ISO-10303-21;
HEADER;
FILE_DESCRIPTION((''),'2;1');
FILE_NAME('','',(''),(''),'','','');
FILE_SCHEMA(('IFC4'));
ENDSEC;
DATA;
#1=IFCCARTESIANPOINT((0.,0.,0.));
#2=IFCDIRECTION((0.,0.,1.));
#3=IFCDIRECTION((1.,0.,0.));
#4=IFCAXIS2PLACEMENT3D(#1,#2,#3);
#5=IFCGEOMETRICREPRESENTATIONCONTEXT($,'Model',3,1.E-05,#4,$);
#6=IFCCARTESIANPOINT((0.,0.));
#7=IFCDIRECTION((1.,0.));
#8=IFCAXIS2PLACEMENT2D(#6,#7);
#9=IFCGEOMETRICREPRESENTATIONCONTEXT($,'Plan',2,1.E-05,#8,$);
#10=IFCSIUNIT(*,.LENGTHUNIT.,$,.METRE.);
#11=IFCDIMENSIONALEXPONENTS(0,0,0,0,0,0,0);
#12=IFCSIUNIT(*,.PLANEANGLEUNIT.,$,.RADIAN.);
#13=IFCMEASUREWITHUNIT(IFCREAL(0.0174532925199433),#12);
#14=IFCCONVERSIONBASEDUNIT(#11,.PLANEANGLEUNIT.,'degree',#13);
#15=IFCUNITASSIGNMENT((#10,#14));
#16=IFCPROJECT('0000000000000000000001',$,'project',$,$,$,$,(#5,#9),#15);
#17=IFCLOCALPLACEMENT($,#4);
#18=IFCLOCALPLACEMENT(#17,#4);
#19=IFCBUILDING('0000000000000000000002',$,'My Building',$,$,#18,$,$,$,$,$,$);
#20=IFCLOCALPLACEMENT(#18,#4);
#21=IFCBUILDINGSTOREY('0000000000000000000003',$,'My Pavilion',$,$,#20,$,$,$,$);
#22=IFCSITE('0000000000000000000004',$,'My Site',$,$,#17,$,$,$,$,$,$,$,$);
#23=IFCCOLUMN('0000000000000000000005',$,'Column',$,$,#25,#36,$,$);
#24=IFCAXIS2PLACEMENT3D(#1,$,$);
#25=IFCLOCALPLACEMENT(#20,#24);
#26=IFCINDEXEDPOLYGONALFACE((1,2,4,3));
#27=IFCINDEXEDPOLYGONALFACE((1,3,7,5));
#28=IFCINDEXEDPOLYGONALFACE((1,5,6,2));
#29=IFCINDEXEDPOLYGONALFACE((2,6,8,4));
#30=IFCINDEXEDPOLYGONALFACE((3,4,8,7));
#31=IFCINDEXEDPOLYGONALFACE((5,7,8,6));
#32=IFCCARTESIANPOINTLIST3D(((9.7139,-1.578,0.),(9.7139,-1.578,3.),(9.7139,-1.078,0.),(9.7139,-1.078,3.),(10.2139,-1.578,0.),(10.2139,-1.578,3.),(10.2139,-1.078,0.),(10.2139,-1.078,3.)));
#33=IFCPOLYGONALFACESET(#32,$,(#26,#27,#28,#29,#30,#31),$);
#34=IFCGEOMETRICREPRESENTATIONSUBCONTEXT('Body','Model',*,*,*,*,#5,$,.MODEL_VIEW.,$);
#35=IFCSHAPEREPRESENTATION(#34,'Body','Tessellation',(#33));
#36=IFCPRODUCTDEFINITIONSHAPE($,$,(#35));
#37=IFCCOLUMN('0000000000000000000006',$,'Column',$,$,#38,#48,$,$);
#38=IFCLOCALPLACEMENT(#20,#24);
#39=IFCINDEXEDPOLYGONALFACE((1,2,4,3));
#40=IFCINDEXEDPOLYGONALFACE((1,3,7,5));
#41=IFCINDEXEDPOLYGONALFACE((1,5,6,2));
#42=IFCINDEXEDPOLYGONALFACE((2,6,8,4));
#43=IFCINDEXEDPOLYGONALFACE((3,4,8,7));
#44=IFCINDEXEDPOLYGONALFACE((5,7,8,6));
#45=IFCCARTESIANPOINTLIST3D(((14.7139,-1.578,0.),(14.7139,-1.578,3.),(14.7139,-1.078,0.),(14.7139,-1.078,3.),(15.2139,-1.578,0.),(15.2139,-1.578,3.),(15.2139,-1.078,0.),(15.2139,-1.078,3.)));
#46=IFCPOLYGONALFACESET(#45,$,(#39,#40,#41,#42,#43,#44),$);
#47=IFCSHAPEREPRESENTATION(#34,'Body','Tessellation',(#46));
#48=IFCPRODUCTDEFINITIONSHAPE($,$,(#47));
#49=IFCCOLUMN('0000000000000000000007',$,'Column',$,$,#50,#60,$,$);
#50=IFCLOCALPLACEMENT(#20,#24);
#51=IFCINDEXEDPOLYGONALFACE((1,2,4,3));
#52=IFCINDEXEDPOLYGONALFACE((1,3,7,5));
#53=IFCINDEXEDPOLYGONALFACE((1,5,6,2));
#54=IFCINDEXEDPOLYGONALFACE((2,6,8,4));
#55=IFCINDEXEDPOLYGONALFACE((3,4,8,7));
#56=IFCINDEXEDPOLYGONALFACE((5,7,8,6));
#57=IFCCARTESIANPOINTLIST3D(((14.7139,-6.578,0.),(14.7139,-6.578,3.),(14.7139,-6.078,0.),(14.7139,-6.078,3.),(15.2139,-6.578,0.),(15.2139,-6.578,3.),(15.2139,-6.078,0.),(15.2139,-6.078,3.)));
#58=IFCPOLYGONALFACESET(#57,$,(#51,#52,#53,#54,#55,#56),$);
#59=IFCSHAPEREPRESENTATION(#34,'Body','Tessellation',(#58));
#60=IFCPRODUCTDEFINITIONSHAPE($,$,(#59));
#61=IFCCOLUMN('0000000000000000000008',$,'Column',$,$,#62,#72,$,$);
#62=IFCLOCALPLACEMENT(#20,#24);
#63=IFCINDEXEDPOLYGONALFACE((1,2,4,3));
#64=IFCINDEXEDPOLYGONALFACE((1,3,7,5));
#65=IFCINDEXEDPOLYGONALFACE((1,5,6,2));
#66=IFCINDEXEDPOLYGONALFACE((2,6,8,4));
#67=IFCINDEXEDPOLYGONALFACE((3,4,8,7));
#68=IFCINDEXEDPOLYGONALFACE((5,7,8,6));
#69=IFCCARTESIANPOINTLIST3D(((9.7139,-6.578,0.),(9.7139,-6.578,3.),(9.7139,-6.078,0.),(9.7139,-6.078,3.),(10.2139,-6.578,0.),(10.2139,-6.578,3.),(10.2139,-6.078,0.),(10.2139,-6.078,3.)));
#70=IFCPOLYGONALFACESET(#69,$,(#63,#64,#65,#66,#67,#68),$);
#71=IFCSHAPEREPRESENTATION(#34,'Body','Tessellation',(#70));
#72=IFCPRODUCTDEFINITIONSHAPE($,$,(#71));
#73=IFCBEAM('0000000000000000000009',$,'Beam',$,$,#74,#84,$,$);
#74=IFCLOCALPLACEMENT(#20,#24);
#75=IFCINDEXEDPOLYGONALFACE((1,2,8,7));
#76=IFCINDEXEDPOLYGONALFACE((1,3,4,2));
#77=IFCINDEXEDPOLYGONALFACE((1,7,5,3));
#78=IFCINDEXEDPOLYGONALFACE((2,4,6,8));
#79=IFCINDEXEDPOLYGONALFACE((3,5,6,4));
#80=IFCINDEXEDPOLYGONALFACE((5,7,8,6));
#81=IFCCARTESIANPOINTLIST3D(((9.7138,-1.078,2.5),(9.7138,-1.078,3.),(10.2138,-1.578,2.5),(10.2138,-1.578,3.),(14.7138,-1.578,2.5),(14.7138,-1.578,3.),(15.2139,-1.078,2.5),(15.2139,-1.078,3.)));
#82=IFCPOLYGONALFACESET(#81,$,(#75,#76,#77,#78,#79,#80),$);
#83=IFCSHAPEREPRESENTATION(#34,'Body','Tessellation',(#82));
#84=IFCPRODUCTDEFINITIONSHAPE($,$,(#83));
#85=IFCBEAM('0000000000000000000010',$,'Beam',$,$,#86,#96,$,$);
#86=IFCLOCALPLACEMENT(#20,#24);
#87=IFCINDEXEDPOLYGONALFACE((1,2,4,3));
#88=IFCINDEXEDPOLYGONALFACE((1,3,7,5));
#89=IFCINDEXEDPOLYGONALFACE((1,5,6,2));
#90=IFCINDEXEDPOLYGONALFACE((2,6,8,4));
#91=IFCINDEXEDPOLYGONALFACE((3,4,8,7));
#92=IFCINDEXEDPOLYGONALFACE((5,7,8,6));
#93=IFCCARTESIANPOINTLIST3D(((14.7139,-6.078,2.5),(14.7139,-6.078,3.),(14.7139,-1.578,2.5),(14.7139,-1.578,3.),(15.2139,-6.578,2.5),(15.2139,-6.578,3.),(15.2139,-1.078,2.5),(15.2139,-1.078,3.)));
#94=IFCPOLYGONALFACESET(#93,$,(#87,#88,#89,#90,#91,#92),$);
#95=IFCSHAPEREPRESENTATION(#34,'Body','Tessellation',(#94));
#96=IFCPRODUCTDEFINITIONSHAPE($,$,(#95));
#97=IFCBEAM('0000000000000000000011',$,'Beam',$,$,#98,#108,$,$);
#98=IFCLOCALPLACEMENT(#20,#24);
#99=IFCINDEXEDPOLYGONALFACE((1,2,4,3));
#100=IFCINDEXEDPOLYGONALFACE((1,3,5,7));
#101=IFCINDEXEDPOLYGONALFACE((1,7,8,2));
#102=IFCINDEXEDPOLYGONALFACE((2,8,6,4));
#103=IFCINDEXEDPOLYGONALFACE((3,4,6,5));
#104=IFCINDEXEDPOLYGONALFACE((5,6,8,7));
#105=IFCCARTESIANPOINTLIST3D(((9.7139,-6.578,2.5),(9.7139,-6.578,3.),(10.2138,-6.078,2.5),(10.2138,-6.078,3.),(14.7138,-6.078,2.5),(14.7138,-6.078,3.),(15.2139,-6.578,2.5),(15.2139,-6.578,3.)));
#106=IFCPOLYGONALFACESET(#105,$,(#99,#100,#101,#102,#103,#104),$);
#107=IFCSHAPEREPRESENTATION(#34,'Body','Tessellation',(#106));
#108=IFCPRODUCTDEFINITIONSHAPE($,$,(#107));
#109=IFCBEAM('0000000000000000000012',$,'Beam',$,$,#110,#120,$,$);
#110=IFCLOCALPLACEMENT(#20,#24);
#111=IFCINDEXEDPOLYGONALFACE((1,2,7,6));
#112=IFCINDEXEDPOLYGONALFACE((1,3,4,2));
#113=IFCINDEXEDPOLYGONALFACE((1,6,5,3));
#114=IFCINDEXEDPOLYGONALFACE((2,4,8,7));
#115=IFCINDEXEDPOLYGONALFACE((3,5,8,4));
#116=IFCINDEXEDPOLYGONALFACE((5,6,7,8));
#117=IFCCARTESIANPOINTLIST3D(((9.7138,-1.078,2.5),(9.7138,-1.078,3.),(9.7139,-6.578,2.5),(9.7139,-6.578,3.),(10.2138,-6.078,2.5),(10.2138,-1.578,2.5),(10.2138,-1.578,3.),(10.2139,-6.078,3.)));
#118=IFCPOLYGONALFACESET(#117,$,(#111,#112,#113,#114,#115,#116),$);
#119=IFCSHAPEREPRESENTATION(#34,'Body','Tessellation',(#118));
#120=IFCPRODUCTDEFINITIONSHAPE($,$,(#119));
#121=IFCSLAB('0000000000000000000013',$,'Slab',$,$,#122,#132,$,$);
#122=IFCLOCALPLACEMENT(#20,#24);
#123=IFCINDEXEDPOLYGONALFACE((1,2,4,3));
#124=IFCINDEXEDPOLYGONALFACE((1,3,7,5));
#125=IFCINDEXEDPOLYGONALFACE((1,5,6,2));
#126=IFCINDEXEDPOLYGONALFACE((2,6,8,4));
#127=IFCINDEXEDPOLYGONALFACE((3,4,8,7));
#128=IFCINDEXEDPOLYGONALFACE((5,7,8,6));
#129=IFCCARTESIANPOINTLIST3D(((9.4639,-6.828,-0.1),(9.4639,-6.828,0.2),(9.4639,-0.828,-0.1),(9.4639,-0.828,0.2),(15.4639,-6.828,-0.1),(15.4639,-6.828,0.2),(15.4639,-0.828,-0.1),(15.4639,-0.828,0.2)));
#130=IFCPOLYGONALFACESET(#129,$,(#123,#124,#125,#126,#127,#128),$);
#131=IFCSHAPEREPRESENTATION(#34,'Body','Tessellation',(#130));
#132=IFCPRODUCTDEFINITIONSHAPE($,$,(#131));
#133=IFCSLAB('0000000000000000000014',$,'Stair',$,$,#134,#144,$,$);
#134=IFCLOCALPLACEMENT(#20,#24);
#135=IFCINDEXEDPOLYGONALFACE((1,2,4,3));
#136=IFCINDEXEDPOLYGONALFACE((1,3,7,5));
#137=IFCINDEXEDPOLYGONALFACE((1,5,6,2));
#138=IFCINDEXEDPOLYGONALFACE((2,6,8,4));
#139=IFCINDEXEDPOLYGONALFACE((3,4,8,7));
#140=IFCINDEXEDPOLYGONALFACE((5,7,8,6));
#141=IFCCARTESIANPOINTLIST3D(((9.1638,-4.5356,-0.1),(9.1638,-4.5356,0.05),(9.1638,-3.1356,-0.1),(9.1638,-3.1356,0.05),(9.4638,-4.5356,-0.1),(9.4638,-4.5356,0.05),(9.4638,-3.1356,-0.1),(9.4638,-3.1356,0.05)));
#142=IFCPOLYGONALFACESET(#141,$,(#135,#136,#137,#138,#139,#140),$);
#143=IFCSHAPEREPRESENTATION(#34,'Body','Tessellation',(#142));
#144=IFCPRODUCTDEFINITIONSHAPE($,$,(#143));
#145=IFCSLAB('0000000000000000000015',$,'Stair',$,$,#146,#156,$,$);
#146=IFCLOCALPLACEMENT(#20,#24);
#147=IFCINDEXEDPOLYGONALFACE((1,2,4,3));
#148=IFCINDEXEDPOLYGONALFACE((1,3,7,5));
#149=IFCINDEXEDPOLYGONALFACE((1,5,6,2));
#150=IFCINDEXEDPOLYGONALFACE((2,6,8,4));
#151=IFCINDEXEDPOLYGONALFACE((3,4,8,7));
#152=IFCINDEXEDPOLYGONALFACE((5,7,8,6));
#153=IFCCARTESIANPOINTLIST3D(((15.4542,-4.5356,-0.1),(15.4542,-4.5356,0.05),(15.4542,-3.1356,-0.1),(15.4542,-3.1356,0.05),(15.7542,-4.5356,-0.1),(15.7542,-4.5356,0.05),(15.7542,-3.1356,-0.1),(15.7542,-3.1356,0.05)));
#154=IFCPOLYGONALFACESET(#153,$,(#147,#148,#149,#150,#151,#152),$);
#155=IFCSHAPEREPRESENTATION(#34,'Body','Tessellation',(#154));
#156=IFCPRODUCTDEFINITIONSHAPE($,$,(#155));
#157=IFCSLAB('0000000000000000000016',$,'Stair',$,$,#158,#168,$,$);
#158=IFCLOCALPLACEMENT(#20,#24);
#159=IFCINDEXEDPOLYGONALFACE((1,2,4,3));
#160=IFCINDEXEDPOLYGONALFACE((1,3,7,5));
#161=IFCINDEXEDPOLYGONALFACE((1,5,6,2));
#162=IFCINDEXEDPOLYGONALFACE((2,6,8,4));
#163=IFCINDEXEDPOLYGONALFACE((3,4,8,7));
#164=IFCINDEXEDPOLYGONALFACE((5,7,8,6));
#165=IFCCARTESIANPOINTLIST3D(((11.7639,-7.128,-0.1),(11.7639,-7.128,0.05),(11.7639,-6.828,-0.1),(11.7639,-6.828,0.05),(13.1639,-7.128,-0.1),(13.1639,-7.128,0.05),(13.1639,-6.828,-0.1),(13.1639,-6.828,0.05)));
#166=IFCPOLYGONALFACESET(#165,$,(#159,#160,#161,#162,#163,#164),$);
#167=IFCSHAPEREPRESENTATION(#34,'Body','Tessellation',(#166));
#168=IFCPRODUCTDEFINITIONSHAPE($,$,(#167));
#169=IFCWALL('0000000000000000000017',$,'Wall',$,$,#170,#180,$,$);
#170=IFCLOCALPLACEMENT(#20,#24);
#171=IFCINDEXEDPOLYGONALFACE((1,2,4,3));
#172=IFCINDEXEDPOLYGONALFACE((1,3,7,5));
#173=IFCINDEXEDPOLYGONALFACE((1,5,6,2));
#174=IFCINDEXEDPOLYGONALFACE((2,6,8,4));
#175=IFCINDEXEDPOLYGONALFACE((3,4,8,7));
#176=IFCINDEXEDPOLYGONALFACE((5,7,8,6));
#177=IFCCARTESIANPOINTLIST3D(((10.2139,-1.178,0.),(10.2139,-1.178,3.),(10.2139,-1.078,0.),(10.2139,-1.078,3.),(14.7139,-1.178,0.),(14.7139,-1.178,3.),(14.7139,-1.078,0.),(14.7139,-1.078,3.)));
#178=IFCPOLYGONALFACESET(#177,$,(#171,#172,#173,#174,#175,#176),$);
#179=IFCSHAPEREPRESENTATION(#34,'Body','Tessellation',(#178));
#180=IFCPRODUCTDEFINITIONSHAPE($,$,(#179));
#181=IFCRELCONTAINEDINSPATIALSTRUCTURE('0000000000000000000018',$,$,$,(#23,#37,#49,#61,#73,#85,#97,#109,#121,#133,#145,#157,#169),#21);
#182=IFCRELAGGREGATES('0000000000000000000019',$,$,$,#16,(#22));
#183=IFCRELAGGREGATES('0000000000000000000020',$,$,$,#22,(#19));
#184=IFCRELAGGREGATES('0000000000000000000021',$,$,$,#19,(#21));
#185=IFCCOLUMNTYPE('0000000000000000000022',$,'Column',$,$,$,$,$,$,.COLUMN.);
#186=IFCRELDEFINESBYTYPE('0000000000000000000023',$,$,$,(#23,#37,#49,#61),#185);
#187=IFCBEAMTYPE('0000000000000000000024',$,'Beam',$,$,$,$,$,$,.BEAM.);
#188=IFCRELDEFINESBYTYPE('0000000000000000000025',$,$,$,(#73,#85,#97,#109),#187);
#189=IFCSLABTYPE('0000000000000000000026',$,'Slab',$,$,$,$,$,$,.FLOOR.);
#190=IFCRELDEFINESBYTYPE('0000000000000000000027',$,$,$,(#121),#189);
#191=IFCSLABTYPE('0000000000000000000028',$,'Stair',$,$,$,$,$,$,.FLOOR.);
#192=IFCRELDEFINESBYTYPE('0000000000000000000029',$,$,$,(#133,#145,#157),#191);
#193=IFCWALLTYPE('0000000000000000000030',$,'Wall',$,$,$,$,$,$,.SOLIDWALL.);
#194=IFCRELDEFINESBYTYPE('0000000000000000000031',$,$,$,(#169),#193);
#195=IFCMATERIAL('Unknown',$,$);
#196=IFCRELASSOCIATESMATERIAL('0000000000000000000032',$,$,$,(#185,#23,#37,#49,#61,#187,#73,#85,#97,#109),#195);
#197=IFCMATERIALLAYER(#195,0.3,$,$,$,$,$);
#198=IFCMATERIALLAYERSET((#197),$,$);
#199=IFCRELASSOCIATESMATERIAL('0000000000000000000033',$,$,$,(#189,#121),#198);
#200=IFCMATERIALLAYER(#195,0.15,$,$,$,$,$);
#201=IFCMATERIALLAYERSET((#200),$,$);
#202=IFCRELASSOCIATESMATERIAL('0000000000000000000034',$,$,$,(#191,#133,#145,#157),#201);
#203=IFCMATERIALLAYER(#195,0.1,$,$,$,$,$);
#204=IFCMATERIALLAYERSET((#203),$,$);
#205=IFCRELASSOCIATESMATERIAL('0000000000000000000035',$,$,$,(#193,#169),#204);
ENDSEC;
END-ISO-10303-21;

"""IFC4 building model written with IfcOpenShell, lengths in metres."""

from ifc_helpers import new_model, entity, si_unit, converted_unit, frame, origin_with_axes, origin_2d_with_axis, place, context, subcontext, project, spatial, line, indexed_curve, rectangle, outline, extrude, clip, halfspace, material, layer, layer_set, layer_usage, material_profile, profile_set, profile_usage, type_object, element, save


model = new_model("IFC4")

# Units and contexts
model_context = context("Model", 3, precision=1e-05, world=origin_with_axes())
plan_context = context("Plan", 2, precision=1e-05, world=origin_2d_with_axis())
body_context = subcontext(model_context, "Body", "Model", "MODEL_VIEW")
ifc_project = project(units=[si_unit("LENGTHUNIT", "METRE"), converted_unit("PLANEANGLEUNIT", "degree", entity("IfcReal", 0.0174532925199433), si_unit("PLANEANGLEUNIT", "RADIAN"), dimensions=[0, 0, 0, 0, 0, 0, 0])], contexts=[model_context, plan_context])

# Site, building, storey
site_placement = place(None, origin_with_axes())
site = spatial("IfcSite", under=ifc_project, at=site_placement, Name="My Site")
building_placement = place(site_placement, origin_with_axes())
building = spatial("IfcBuilding", under=site, at=building_placement, Name="My Building")
storey_placement = place(building_placement, origin_with_axes())
storey = spatial("IfcBuildingStorey", under=building, at=storey_placement, Name="My Pavilion")

# Columns
ifc_material = material(Name="Unknown")
ifc_material_profile_1 = material_profile(ifc_material, rectangle(XDim=0.5, YDim=0.5))
ifc_profile_set_1 = profile_set([ifc_material_profile_1])
ifc_profile_usage_1 = profile_usage(ifc_profile_set_1, cardinal=5)
column_type = type_object("IfcColumnType", Name="Column", PredefinedType="COLUMN", material=ifc_profile_set_1)
column_1_placement = place(storey_placement, frame((9.9639, -1.328, 0.0), z_axis=(0.0, 0.0, 1.0), x_axis=(1.0, 0.0, 0.0)))
element("IfcColumn", 1, at=column_1_placement, inside=storey, type_object=column_type, material=ifc_profile_usage_1, Name="Column", context=body_context, shape_type="SweptSolid", body=[
    extrude(rectangle(XDim=0.5, YDim=0.5), origin_with_axes(), (0.0, 0.0, 1.0), 3.0),
])
ifc_profile_usage_2 = profile_usage(ifc_profile_set_1, cardinal=5)
column_2_placement = place(storey_placement, frame((14.9639, -1.328, 0.0), z_axis=(0.0, 0.0, 1.0), x_axis=(1.0, 0.0, 0.0)))
element("IfcColumn", 2, at=column_2_placement, inside=storey, type_object=column_type, material=ifc_profile_usage_2, Name="Column", context=body_context, shape_type="SweptSolid", body=[
    extrude(rectangle(XDim=0.5, YDim=0.5), origin_with_axes(), (0.0, 0.0, 1.0), 3.0),
])
ifc_profile_usage_3 = profile_usage(ifc_profile_set_1, cardinal=5)
column_3_placement = place(storey_placement, frame((14.9639, -6.328, 0.0), z_axis=(0.0, 0.0, 1.0), x_axis=(1.0, 0.0, 0.0)))
element("IfcColumn", 3, at=column_3_placement, inside=storey, type_object=column_type, material=ifc_profile_usage_3, Name="Column", context=body_context, shape_type="SweptSolid", body=[
    extrude(rectangle(XDim=0.5, YDim=0.5), origin_with_axes(), (0.0, 0.0, 1.0), 3.0),
])
ifc_profile_usage_4 = profile_usage(ifc_profile_set_1, cardinal=5)
column_4_placement = place(storey_placement, frame((9.9639, -6.328, 0.0), z_axis=(0.0, 0.0, 1.0), x_axis=(1.0, 0.0, 0.0)))
element("IfcColumn", 4, at=column_4_placement, inside=storey, type_object=column_type, material=ifc_profile_usage_4, Name="Column", context=body_context, shape_type="SweptSolid", body=[
    extrude(rectangle(XDim=0.5, YDim=0.5), origin_with_axes(), (0.0, 0.0, 1.0), 3.0),
])

# Beams
ifc_material_profile_2 = material_profile(ifc_material, rectangle(XDim=0.5, YDim=0.5))
ifc_profile_set_2 = profile_set([ifc_material_profile_2])
ifc_profile_usage_5 = profile_usage(ifc_profile_set_2, cardinal=1)
beam_type = type_object("IfcBeamType", Name="Beam", PredefinedType="BEAM", material=ifc_profile_set_2)
beam_1_placement = place(storey_placement, frame((9.7138, -1.078, 2.5), z_axis=(1.0, 0.0, 0.0), x_axis=(0.0, 1.0, 0.0)))
element("IfcBeam", 5, at=beam_1_placement, inside=storey, type_object=beam_type, material=ifc_profile_usage_5, Name="Beam", context=body_context, shape_type="Clipping", body=[
    clip(clip(extrude(rectangle(XDim=0.5, YDim=0.5), frame((-0.25, 0.25, 0.0), z_axis=(0.0, 0.0, 1.0), x_axis=(1.0, 0.0, 0.0)), (0.0, 0.0, 1.0), 5.5), halfspace(frame((0.0, -3.0, 5.5), z_axis=(-0.707107, 0.0, 0.707107), x_axis=(0.0, 1.0, 0.0)), False)), halfspace(frame((0.0, -3.0, 0.0), z_axis=(-0.707107, 0.0, -0.707107), x_axis=(0.0, 1.0, 0.0)), False)),
])
ifc_profile_usage_6 = profile_usage(ifc_profile_set_2, cardinal=1)
beam_2_placement = place(storey_placement, frame((15.2139, -1.078, 2.5), z_axis=(0.0, -1.0, 0.0), x_axis=(1.0, 0.0, 0.0)))
element("IfcBeam", 6, at=beam_2_placement, inside=storey, type_object=beam_type, material=ifc_profile_usage_6, Name="Beam", context=body_context, shape_type="Clipping", body=[
    clip(clip(extrude(rectangle(XDim=0.5, YDim=0.5), frame((-0.25, 0.25, 0.0), z_axis=(0.0, 0.0, 1.0), x_axis=(1.0, 0.0, 0.0)), (0.0, 0.0, 1.0), 5.5), halfspace(frame((0.0, -3.0, 5.5), z_axis=(-0.707107, 0.0, 0.707107), x_axis=(0.0, 1.0, 0.0)), False)), halfspace(frame((0.0, -3.0, 0.0), z_axis=(-0.707107, 0.0, -0.707107), x_axis=(0.0, 1.0, 0.0)), False)),
])
ifc_profile_usage_7 = profile_usage(ifc_profile_set_2, cardinal=1)
beam_3_placement = place(storey_placement, frame((15.2139, -6.578, 2.5), z_axis=(-1.0, 0.0, 0.0), x_axis=(0.0, -1.0, 0.0)))
element("IfcBeam", 7, at=beam_3_placement, inside=storey, type_object=beam_type, material=ifc_profile_usage_7, Name="Beam", context=body_context, shape_type="Clipping", body=[
    clip(clip(extrude(rectangle(XDim=0.5, YDim=0.5), frame((-0.25, 0.25, 0.0), z_axis=(0.0, 0.0, 1.0), x_axis=(1.0, 0.0, 0.0)), (0.0, 0.0, 1.0), 5.5), halfspace(frame((0.0, -3.0, 5.5), z_axis=(-0.707107, 0.0, 0.707107), x_axis=(0.0, 1.0, 0.0)), False)), halfspace(frame((0.0, -3.0, 0.0), z_axis=(-0.707107, 0.0, -0.707107), x_axis=(0.0, 1.0, 0.0)), False)),
])
ifc_profile_usage_8 = profile_usage(ifc_profile_set_2, cardinal=1)
beam_4_placement = place(storey_placement, frame((9.7139, -6.578, 2.5), z_axis=(0.0, 1.0, 0.0), x_axis=(-1.0, 0.0, 0.0)))
element("IfcBeam", 8, at=beam_4_placement, inside=storey, type_object=beam_type, material=ifc_profile_usage_8, Name="Beam", context=body_context, shape_type="Clipping", body=[
    clip(clip(extrude(rectangle(XDim=0.5, YDim=0.5), frame((-0.25, 0.25, 0.0), z_axis=(0.0, 0.0, 1.0), x_axis=(1.0, 0.0, 0.0)), (0.0, 0.0, 1.0), 5.5), halfspace(frame((0.0, -3.0, 5.5), z_axis=(-0.707107, 0.0, 0.707107), x_axis=(0.0, 1.0, 0.0)), False)), halfspace(frame((0.0, -3.0, 0.0), z_axis=(-0.707107, 0.0, -0.707107), x_axis=(0.0, 1.0, 0.0)), False)),
])

# Slabs
ifc_layer_1 = layer(ifc_material, 0.3)
ifc_layer_set_1 = layer_set([ifc_layer_1])
ifc_layer_usage_1 = layer_usage(ifc_layer_set_1, "AXIS3", "POSITIVE", -0.1)
slab_type_1 = type_object("IfcSlabType", Name="Slab", PredefinedType="FLOOR", material=ifc_layer_set_1)
slab_1_placement = place(storey_placement, frame((9.4639, -0.828, 0.0), z_axis=(0.0, 0.0, 1.0), x_axis=(1.0, 0.0, 0.0)))
element("IfcSlab", 9, at=slab_1_placement, inside=storey, type_object=slab_type_1, material=ifc_layer_usage_1, Name="Slab", context=body_context, shape_type="SweptSolid", body=[
    extrude(outline(indexed_curve([(0.0, 0.0), (6.0, 0.0), (6.0, -6.0), (0.0, -6.0), (0.0, 0.0)])), frame((0.0, 0.0, -0.1), z_axis=(0.0, 0.0, 1.0), x_axis=(1.0, 0.0, 0.0)), (0.0, 0.0, 1.0), 0.3),
])
ifc_layer_2 = layer(ifc_material, 0.15)
ifc_layer_set_2 = layer_set([ifc_layer_2])
ifc_layer_usage_2 = layer_usage(ifc_layer_set_2, "AXIS3", "POSITIVE", -1.0)
slab_type_2 = type_object("IfcSlabType", Name="Stair", PredefinedType="FLOOR", material=ifc_layer_set_2)
slab_2_placement = place(storey_placement, frame((9.1638, -4.5356, 0.9), z_axis=(0.0, 0.0, 1.0), x_axis=(0.0, 1.0, 0.0)))
element("IfcSlab", 10, at=slab_2_placement, inside=storey, type_object=slab_type_2, material=ifc_layer_usage_2, Name="Stair", context=body_context, shape_type="SweptSolid", body=[
    extrude(outline(indexed_curve([(0.0, 0.0), (1.4, 0.0), (1.4, -0.3), (0.0, -0.3), (0.0, 0.0)])), frame((0.0, 0.0, -1.0), z_axis=(0.0, 0.0, 1.0), x_axis=(1.0, 0.0, 0.0)), (0.0, 0.0, 1.0), 0.15),
])
ifc_layer_usage_3 = layer_usage(ifc_layer_set_2, "AXIS3", "POSITIVE", -1.0)
slab_3_placement = place(storey_placement, frame((15.4542, -4.5356, 0.9), z_axis=(0.0, 0.0, 1.0), x_axis=(0.0, 1.0, 0.0)))
element("IfcSlab", 11, at=slab_3_placement, inside=storey, type_object=slab_type_2, material=ifc_layer_usage_3, Name="Stair", context=body_context, shape_type="SweptSolid", body=[
    extrude(outline(indexed_curve([(0.0, 0.0), (1.4, 0.0), (1.4, -0.3), (0.0, -0.3), (0.0, 0.0)])), frame((0.0, 0.0, -1.0), z_axis=(0.0, 0.0, 1.0), x_axis=(1.0, 0.0, 0.0)), (0.0, 0.0, 1.0), 0.15),
])
ifc_layer_usage_4 = layer_usage(ifc_layer_set_2, "AXIS3", "POSITIVE", -1.0)
slab_4_placement = place(storey_placement, frame((13.1639, -7.128, 0.9), z_axis=(0.0, 0.0, 1.0), x_axis=(-1.0, 0.0, 0.0)))
element("IfcSlab", 12, at=slab_4_placement, inside=storey, type_object=slab_type_2, material=ifc_layer_usage_4, Name="Stair", context=body_context, shape_type="SweptSolid", body=[
    extrude(outline(indexed_curve([(0.0, 0.0), (1.4, 0.0), (1.4, -0.3), (0.0, -0.3), (0.0, 0.0)])), frame((0.0, 0.0, -1.0), z_axis=(0.0, 0.0, 1.0), x_axis=(1.0, 0.0, 0.0)), (0.0, 0.0, 1.0), 0.15),
])

# Wall
ifc_layer_3 = layer(ifc_material, 0.1)
ifc_layer_set_3 = layer_set([ifc_layer_3])
ifc_layer_usage_5 = layer_usage(ifc_layer_set_3, "AXIS2", "POSITIVE", 0.0)
wall_type = type_object("IfcWallType", Name="Wall", PredefinedType="SOLIDWALL", material=ifc_layer_set_3)
wall_placement = place(storey_placement, frame((14.7139, -1.078, 0.0), z_axis=(0.0, 0.0, 1.0), x_axis=(-1.0, 0.0, 0.0)))
element("IfcWall", 13, at=wall_placement, inside=storey, type_object=wall_type, material=ifc_layer_usage_5, Name="Wall", context=body_context, shape_type="SweptSolid", body=[
    extrude(outline(indexed_curve([(0.0, 0.0), (0.0, 0.1), (4.5, 0.1), (4.5, 0.0)], segments=[line(1, 2, 3, 4, 1)])), origin_with_axes(), (0.0, 0.0, 1.0), 3.0),
])

save(model, "model.ifc")
